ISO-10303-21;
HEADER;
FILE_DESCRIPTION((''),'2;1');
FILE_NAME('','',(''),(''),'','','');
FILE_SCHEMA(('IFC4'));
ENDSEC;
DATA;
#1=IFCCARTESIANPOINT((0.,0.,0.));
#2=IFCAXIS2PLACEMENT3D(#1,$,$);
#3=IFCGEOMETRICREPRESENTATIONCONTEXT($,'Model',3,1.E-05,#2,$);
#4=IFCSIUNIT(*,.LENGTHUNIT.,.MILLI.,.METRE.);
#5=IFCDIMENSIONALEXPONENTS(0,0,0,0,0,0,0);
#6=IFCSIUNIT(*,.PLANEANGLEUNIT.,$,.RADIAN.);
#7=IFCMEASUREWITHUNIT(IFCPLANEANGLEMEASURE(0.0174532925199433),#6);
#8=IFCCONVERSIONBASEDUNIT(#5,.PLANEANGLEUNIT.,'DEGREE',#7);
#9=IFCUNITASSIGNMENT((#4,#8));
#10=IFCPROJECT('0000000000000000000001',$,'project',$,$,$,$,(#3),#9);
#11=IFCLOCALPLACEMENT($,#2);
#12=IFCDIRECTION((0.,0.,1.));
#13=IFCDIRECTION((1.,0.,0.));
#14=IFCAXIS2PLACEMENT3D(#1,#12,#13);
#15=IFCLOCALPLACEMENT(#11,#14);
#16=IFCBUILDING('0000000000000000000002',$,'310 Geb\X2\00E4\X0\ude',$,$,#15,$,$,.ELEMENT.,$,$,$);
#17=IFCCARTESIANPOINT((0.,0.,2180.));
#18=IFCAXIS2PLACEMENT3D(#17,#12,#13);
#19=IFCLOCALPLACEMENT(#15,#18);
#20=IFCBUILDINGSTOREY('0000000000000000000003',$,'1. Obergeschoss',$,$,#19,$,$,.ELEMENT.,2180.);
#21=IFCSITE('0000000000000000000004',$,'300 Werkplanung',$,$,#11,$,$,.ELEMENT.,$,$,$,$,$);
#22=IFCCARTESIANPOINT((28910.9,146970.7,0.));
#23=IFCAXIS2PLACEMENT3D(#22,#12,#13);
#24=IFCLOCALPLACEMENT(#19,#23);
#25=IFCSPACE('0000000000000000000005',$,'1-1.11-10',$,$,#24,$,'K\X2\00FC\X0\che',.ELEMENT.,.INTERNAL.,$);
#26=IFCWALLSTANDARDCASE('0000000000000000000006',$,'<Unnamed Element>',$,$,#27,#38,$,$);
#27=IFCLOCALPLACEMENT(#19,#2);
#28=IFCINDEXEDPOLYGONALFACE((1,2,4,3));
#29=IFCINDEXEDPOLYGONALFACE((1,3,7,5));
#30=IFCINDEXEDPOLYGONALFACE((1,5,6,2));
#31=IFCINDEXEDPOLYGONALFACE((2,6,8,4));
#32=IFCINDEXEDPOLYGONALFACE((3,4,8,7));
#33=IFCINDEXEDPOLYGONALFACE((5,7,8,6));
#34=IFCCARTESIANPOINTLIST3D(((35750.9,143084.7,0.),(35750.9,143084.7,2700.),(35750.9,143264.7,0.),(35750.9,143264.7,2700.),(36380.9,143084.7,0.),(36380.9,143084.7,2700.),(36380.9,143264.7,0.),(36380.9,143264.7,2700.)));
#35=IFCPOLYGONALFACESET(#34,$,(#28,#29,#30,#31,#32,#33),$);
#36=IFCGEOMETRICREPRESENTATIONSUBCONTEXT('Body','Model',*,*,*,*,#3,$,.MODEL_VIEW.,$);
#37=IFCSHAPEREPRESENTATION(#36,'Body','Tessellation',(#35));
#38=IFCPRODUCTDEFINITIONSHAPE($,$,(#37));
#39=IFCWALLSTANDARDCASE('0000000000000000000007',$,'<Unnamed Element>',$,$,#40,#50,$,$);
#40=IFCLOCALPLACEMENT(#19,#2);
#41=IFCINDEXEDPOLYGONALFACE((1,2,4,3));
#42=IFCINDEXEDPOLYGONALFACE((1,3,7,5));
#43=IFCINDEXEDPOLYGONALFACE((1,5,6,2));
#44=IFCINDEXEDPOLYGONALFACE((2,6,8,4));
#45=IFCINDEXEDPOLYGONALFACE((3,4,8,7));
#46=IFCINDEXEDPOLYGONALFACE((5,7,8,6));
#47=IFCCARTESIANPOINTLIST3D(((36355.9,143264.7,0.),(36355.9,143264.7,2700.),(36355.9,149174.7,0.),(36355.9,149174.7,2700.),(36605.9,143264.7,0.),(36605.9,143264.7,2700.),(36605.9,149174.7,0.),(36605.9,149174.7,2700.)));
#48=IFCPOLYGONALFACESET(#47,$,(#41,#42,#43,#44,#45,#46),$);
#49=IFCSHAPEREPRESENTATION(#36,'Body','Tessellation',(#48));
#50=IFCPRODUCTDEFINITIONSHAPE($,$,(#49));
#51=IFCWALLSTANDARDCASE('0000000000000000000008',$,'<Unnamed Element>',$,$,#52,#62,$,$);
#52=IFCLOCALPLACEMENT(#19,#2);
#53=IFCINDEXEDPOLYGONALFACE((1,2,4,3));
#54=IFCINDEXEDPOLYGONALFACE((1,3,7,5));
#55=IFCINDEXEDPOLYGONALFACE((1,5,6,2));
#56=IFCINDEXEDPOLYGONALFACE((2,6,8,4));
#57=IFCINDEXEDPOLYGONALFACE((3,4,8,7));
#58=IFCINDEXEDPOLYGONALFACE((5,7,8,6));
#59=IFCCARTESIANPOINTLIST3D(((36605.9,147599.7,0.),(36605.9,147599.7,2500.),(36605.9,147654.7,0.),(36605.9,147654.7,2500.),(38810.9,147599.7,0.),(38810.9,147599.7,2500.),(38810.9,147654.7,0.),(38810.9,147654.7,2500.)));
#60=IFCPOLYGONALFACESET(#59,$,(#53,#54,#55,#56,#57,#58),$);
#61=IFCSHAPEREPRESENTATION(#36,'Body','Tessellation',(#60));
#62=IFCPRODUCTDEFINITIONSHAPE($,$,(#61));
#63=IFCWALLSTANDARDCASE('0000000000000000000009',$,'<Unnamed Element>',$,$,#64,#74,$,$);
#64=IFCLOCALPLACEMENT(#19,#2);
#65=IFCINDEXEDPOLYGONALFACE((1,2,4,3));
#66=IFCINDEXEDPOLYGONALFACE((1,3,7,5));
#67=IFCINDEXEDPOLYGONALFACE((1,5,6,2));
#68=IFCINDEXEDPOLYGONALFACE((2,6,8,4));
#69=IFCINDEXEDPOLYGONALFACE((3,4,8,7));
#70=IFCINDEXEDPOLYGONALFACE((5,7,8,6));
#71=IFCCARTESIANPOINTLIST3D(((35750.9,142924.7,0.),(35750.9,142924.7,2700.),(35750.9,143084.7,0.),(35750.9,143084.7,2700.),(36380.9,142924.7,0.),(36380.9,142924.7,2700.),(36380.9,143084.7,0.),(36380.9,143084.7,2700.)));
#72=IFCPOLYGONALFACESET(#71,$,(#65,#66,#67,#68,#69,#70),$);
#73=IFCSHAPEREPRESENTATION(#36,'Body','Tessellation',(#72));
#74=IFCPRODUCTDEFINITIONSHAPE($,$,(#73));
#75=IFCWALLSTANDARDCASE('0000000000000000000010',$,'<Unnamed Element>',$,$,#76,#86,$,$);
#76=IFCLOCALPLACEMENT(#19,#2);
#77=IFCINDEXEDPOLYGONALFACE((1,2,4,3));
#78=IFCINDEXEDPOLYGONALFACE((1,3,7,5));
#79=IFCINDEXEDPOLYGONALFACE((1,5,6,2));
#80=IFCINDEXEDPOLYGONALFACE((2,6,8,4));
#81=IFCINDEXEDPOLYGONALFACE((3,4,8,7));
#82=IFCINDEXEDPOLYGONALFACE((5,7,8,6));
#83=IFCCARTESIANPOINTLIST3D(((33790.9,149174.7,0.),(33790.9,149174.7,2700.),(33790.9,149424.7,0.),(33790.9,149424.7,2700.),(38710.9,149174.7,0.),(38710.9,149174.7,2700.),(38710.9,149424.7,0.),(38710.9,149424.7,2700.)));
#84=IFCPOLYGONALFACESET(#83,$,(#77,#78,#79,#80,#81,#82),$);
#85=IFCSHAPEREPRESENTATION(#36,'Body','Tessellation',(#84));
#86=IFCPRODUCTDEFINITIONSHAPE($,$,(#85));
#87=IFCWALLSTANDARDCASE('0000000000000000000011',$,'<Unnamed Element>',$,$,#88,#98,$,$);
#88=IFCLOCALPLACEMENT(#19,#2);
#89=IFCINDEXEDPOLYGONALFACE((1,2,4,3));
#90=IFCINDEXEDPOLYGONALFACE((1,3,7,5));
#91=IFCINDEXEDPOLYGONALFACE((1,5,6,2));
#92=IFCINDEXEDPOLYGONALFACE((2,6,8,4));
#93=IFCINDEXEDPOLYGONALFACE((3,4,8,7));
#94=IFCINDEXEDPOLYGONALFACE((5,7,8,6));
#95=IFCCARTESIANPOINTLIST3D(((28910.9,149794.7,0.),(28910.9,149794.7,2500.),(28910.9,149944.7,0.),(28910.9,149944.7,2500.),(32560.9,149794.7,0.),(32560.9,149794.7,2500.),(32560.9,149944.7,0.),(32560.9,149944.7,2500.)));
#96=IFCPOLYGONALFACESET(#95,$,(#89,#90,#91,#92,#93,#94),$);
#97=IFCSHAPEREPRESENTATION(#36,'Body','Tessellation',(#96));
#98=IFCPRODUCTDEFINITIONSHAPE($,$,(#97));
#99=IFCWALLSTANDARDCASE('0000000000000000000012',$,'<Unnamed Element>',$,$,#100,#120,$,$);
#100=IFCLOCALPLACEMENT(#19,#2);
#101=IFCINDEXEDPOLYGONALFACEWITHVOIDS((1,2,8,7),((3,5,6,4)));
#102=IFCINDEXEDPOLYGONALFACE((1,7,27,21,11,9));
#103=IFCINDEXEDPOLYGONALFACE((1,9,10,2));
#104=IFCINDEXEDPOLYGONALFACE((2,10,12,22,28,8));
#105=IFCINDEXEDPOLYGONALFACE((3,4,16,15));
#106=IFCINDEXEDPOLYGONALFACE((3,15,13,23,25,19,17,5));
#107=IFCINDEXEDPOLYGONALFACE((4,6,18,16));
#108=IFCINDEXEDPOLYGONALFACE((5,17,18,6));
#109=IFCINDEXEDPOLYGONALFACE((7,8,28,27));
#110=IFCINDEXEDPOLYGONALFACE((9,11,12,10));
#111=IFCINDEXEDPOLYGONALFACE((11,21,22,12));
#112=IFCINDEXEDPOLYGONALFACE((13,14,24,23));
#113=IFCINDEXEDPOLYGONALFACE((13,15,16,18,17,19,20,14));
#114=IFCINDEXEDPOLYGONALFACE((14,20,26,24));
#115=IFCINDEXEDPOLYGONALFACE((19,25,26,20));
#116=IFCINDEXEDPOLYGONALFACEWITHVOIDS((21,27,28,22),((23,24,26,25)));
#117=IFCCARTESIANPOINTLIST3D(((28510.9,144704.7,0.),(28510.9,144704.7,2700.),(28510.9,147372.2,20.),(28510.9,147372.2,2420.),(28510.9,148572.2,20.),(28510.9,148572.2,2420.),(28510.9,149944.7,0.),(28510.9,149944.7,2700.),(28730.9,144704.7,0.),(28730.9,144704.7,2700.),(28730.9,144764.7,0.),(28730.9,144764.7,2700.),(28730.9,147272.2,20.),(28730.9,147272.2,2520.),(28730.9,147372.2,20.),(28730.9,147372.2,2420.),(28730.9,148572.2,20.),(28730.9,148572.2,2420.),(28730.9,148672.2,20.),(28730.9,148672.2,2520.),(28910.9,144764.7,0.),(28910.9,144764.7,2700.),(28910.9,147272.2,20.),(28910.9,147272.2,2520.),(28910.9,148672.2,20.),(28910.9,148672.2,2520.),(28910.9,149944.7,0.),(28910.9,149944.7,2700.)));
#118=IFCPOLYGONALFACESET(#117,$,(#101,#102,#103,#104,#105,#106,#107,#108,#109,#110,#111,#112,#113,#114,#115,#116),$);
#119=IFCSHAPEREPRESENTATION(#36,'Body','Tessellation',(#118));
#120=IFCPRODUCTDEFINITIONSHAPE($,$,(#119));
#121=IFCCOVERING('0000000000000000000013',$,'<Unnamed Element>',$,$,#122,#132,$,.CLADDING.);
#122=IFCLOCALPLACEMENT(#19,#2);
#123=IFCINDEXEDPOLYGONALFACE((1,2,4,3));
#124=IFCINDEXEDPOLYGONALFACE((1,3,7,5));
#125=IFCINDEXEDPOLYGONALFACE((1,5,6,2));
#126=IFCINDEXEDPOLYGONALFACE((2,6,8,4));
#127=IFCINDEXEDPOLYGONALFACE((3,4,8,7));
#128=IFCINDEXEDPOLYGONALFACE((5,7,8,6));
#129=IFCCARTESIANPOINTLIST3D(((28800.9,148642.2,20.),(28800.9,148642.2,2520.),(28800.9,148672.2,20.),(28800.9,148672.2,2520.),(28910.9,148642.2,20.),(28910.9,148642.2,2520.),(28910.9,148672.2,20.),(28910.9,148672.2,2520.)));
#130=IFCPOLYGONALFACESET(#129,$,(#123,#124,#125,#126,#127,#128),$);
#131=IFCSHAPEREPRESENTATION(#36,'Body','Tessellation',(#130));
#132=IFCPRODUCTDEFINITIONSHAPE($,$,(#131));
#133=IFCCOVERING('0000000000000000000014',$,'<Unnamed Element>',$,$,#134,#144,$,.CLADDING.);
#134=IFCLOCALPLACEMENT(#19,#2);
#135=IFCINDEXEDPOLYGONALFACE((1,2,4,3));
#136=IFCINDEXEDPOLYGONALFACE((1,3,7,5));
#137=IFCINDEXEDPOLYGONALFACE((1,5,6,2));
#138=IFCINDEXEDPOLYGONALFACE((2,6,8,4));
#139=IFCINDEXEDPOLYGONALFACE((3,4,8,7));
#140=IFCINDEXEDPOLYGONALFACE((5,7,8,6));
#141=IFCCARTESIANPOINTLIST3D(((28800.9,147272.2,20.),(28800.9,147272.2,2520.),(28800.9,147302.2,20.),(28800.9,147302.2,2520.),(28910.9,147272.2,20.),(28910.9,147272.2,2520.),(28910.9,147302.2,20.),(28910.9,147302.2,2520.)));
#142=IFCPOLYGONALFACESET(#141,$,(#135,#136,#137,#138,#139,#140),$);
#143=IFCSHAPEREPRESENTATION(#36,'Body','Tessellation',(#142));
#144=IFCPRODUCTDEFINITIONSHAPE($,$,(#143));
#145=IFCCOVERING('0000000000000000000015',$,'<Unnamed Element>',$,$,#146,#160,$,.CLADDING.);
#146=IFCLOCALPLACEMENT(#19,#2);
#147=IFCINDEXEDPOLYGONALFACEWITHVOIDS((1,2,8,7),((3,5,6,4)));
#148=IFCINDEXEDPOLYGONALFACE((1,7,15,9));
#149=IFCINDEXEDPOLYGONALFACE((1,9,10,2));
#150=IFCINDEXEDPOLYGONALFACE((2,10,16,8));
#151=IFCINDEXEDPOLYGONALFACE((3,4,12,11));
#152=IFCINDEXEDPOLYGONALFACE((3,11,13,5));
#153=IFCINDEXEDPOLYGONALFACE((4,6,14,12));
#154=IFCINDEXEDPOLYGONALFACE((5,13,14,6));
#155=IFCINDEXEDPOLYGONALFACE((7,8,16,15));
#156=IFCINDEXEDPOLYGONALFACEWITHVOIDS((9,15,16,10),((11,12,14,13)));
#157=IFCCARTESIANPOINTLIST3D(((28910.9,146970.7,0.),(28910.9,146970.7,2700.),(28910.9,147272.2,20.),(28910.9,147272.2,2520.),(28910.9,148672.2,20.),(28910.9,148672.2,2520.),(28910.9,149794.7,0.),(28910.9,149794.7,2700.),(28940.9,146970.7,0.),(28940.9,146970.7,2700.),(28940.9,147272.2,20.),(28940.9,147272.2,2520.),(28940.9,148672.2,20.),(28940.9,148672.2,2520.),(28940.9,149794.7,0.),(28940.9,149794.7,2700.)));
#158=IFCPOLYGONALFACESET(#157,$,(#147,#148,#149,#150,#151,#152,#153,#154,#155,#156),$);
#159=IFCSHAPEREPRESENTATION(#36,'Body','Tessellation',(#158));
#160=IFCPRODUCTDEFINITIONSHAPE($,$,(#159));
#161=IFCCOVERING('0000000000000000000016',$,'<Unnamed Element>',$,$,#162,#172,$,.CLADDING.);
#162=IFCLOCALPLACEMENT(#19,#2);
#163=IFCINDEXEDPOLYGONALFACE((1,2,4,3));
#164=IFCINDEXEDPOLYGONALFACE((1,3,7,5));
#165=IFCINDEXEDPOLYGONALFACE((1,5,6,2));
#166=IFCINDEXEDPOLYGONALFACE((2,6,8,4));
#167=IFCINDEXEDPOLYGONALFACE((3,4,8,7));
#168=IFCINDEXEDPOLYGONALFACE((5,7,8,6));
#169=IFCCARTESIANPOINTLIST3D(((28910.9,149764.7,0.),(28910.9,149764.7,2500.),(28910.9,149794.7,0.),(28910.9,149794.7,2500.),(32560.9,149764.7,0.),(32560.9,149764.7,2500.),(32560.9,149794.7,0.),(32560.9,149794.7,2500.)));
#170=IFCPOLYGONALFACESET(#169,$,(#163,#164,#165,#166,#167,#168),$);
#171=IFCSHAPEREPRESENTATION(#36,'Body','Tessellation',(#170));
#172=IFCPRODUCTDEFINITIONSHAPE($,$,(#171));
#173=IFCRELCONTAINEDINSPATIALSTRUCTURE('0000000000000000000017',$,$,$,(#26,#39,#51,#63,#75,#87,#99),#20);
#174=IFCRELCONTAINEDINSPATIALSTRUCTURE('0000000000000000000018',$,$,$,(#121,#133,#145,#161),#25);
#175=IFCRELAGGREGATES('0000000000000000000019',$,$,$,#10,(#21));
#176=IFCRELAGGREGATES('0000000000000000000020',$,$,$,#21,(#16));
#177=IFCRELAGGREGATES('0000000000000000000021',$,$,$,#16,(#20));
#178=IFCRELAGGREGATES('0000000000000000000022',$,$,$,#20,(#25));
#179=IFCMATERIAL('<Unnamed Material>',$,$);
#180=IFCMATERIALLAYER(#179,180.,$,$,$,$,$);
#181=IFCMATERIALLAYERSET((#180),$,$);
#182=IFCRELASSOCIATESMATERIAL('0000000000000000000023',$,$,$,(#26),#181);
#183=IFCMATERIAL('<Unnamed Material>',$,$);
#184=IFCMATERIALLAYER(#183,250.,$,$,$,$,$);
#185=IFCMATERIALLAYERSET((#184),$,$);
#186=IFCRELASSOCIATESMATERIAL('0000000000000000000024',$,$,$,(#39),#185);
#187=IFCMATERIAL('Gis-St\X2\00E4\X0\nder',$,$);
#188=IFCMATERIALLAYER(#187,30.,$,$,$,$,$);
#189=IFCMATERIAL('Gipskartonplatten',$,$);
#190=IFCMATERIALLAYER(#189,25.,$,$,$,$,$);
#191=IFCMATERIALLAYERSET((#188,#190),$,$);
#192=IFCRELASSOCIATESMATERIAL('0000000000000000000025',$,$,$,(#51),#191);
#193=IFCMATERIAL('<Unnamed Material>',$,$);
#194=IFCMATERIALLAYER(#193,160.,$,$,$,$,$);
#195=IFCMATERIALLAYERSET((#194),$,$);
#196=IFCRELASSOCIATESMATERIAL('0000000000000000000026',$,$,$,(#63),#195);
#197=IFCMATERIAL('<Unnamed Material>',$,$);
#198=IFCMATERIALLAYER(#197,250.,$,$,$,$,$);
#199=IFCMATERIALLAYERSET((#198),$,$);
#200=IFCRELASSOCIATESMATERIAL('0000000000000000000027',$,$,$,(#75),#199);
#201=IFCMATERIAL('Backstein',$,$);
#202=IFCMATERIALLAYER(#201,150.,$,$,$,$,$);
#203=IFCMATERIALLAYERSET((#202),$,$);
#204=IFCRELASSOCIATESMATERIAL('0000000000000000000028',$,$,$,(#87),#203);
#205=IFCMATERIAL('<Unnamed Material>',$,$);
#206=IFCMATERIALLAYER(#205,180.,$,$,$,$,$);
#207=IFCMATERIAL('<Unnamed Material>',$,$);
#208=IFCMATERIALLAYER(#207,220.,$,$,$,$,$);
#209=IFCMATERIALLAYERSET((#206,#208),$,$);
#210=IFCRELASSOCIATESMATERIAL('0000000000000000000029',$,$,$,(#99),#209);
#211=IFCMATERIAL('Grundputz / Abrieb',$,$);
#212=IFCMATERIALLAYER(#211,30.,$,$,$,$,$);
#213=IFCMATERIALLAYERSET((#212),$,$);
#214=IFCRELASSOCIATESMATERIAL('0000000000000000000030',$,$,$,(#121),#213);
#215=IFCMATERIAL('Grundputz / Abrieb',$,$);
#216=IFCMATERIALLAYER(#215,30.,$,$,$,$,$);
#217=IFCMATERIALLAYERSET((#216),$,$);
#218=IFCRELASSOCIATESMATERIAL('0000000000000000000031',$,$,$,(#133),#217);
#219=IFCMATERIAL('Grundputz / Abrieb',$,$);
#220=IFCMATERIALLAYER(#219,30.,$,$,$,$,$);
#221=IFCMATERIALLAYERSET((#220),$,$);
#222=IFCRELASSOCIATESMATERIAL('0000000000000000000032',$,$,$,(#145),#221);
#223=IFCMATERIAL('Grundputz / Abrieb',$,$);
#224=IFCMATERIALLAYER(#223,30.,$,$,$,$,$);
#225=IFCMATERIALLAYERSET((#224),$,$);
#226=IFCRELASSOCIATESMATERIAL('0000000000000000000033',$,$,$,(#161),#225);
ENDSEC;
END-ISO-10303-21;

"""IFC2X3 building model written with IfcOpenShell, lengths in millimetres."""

from ifc_helpers import new_model, entity, si_unit, converted_unit, frame, frame_2d, origin, origin_with_axes, place, context, subcontext, project, spatial, polyline, rectangle, outline, extrude, material, layer, layer_set, layer_usage, element, save


model = new_model("IFC2X3")

# Units and contexts
model_context = context("Model", 3, precision=1e-05, world=origin())
body_context = subcontext(model_context, "Body", "Model", "MODEL_VIEW")
ifc_project = project(units=[si_unit("LENGTHUNIT", "METRE", prefix="MILLI"), converted_unit("PLANEANGLEUNIT", "DEGREE", entity("IfcPlaneAngleMeasure", 0.0174532925199433), si_unit("PLANEANGLEUNIT", "RADIAN"), dimensions=[0, 0, 0, 0, 0, 0, 0])], contexts=[model_context])

# Site, building, storey
site_placement = place(None, origin())
site = spatial("IfcSite", under=ifc_project, at=site_placement, Name="300 Werkplanung", CompositionType="ELEMENT")
building_placement = place(site_placement, origin_with_axes())
building = spatial("IfcBuilding", under=site, at=building_placement, Name="310 Gebäude", CompositionType="ELEMENT")
storey_placement = place(building_placement, frame((0.0, 0.0, 2180.0), z_axis=(0.0, 0.0, 1.0), x_axis=(1.0, 0.0, 0.0)))
storey = spatial("IfcBuildingStorey", under=building, at=storey_placement, Name="1. Obergeschoss", CompositionType="ELEMENT", Elevation=2180.0)

# Walls
ifc_material_1 = material(Name="<Unnamed Material>")
ifc_layer_1 = layer(ifc_material_1, 180.0)
ifc_layer_set_1 = layer_set([ifc_layer_1])
ifc_layer_usage_1 = layer_usage(ifc_layer_set_1, "AXIS2", "POSITIVE", 0.0)
wall_1_placement = place(storey_placement, frame((35750.9, 143084.7, 0.0), z_axis=(0.0, 0.0, 1.0), x_axis=(1.0, 0.0, 0.0)))
element("IfcWallStandardCase", 1, at=wall_1_placement, inside=storey, material=ifc_layer_usage_1, Name="<Unnamed Element>", context=body_context, shape_type="SweptSolid", body=[
    extrude(rectangle(XDim=630.0, YDim=180.0, at=frame_2d((315.0, 90.0), x_axis=(1.0, 0.0))), origin_with_axes(), (0.0, 0.0, 1.0), 2700.0),
])
ifc_material_2 = material(Name="<Unnamed Material>")
ifc_layer_2 = layer(ifc_material_2, 250.0)
ifc_layer_set_2 = layer_set([ifc_layer_2])
ifc_layer_usage_2 = layer_usage(ifc_layer_set_2, "AXIS2", "POSITIVE", -125.0)
wall_2_placement = place(storey_placement, frame((36605.9, 143264.7, 0.0), z_axis=(0.0, 0.0, 1.0), x_axis=(0.0, 1.0, 0.0)))
element("IfcWallStandardCase", 2, at=wall_2_placement, inside=storey, material=ifc_layer_usage_2, Name="<Unnamed Element>", context=body_context, shape_type="SweptSolid", body=[
    extrude(rectangle(XDim=5910.0, YDim=250.0, at=frame_2d((2955.0, 125.0), x_axis=(1.0, 0.0))), origin_with_axes(), (0.0, 0.0, 1.0), 2700.0),
])
ifc_material_3 = material(Name="Gis-Ständer")
ifc_layer_3 = layer(ifc_material_3, 30.0)
ifc_material_4 = material(Name="Gipskartonplatten")
ifc_layer_4 = layer(ifc_material_4, 25.0)
ifc_layer_set_3 = layer_set([ifc_layer_3, ifc_layer_4])
ifc_layer_usage_3 = layer_usage(ifc_layer_set_3, "AXIS2", "POSITIVE", -55.0)
wall_3_placement = place(storey_placement, frame((36605.9, 147599.7, 0.0), z_axis=(0.0, 0.0, 1.0), x_axis=(1.0, 0.0, 0.0)))
element("IfcWallStandardCase", 3, at=wall_3_placement, inside=storey, material=ifc_layer_usage_3, Name="<Unnamed Element>", context=body_context, shape_type="SweptSolid", body=[
    extrude(rectangle(XDim=2205.0, YDim=55.0, at=frame_2d((1102.5, 27.5), x_axis=(1.0, 0.0))), origin_with_axes(), (0.0, 0.0, 1.0), 2500.0),
])
ifc_material_5 = material(Name="<Unnamed Material>")
ifc_layer_5 = layer(ifc_material_5, 160.0)
ifc_layer_set_4 = layer_set([ifc_layer_5])
ifc_layer_usage_4 = layer_usage(ifc_layer_set_4, "AXIS2", "POSITIVE", 0.0)
wall_4_placement = place(storey_placement, frame((36380.9, 143084.7, 0.0), z_axis=(0.0, 0.0, 1.0), x_axis=(-1.0, 0.0, 0.0)))
element("IfcWallStandardCase", 4, at=wall_4_placement, inside=storey, material=ifc_layer_usage_4, Name="<Unnamed Element>", context=body_context, shape_type="SweptSolid", body=[
    extrude(rectangle(XDim=630.0, YDim=160.0, at=frame_2d((315.0, 80.0), x_axis=(1.0, 0.0))), origin_with_axes(), (0.0, 0.0, 1.0), 2700.0),
])
ifc_material_6 = material(Name="<Unnamed Material>")
ifc_layer_6 = layer(ifc_material_6, 250.0)
ifc_layer_set_5 = layer_set([ifc_layer_6])
ifc_layer_usage_5 = layer_usage(ifc_layer_set_5, "AXIS2", "POSITIVE", -250.0)
wall_5_placement = place(storey_placement, frame((33790.9, 149174.7, 0.0), z_axis=(0.0, 0.0, 1.0), x_axis=(1.0, 0.0, 0.0)))
element("IfcWallStandardCase", 5, at=wall_5_placement, inside=storey, material=ifc_layer_usage_5, Name="<Unnamed Element>", context=body_context, shape_type="SweptSolid", body=[
    extrude(rectangle(XDim=4920.0, YDim=250.0, at=frame_2d((2460.0, 125.0), x_axis=(1.0, 0.0))), origin_with_axes(), (0.0, 0.0, 1.0), 2700.0),
])
ifc_material_7 = material(Name="Backstein")
ifc_layer_7 = layer(ifc_material_7, 150.0)
ifc_layer_set_6 = layer_set([ifc_layer_7])
ifc_layer_usage_6 = layer_usage(ifc_layer_set_6, "AXIS2", "POSITIVE", 0.0)
wall_6_placement = place(storey_placement, frame((28910.9, 149794.7, 0.0), z_axis=(0.0, 0.0, 1.0), x_axis=(1.0, 0.0, 0.0)))
element("IfcWallStandardCase", 6, at=wall_6_placement, inside=storey, material=ifc_layer_usage_6, Name="<Unnamed Element>", context=body_context, shape_type="SweptSolid", body=[
    extrude(rectangle(XDim=3650.0, YDim=150.0, at=frame_2d((1825.0, 75.0), x_axis=(1.0, 0.0))), origin_with_axes(), (0.0, 0.0, 1.0), 2500.0),
])

# Wall, opening
ifc_material_8 = material(Name="<Unnamed Material>")
ifc_layer_8 = layer(ifc_material_8, 180.0)
ifc_material_9 = material(Name="<Unnamed Material>")
ifc_layer_9 = layer(ifc_material_9, 220.0)
ifc_layer_set_7 = layer_set([ifc_layer_8, ifc_layer_9])
ifc_layer_usage_7 = layer_usage(ifc_layer_set_7, "AXIS2", "POSITIVE", -175.0)
wall_7_placement = place(storey_placement, frame((28910.9, 144764.7, 0.0), z_axis=(0.0, 0.0, 1.0), x_axis=(0.0, 1.0, 0.0)))
wall_7 = element("IfcWallStandardCase", 7, at=wall_7_placement, inside=storey, material=ifc_layer_usage_7, Name="<Unnamed Element>", context=body_context, shape_type="SweptSolid", body=[
    extrude(outline(polyline([(-60.0, 400.0), (-60.0, 180.0), (0.0, 180.0), (0.0, 0.0), (5180.0, 0.0), (5180.0, 400.0), (-60.0, 400.0)])), origin_with_axes(), (0.0, 0.0, 1.0), 2700.0),
])
opening_placement = place(wall_7_placement, frame((2507.5, 0.0, 20.0), z_axis=(0.0, 1.0, 0.0), x_axis=(0.0, 0.0, 1.0)))
element("IfcOpeningElement", 8, at=opening_placement, cuts=wall_7, ObjectType="Opening", context=body_context, shape_type="SweptSolid", body=[
    extrude(rectangle(XDim=2500.0, YDim=1400.0, at=frame_2d((1250.0, 700.0), x_axis=(1.0, 0.0))), origin_with_axes(), (0.0, 0.0, 1.0), 180.0),
    extrude(rectangle(XDim=2400.0, YDim=1200.0, at=frame_2d((1200.0, 600.0), x_axis=(1.0, 0.0))), frame((0.0, 100.0, 180.0), z_axis=(0.0, 0.0, 1.0), x_axis=(1.0, 0.0, 0.0)), (0.0, 0.0, 1.0), 220.0),
])

# Shared definitions
space_1_placement = place(storey_placement, frame((28910.9, 146970.7, 0.0), z_axis=(0.0, 0.0, 1.0), x_axis=(1.0, 0.0, 0.0)))
space_1 = spatial("IfcSpace", under=storey, at=space_1_placement, Name="1-1.11-10", LongName="Küche", CompositionType="ELEMENT", InteriorOrExteriorSpace="INTERNAL")

# Coverings
ifc_material_10 = material(Name="Grundputz / Abrieb")
ifc_layer_10 = layer(ifc_material_10, 30.0)
ifc_layer_set_8 = layer_set([ifc_layer_10])
ifc_layer_usage_8 = layer_usage(ifc_layer_set_8, "AXIS3", "POSITIVE", 0.0)
covering_1_placement = place(space_1_placement, frame((0.0, 1701.5, 20.0), z_axis=(0.0, 0.0, 1.0), x_axis=(-1.0, 0.0, 0.0)))
element("IfcCovering", 9, at=covering_1_placement, inside=space_1, material=ifc_layer_usage_8, Name="<Unnamed Element>", PredefinedType="CLADDING", context=body_context, shape_type="SweptSolid", body=[
    extrude(rectangle(XDim=2500.0, YDim=110.0, at=frame_2d((-55.0, 1250.0), x_axis=(0.0, 1.0))), frame((110.0, 0.0, 2500.0), z_axis=(0.0, 1.0, 0.0), x_axis=(1.0, 0.0, 0.0)), (0.0, 0.0, 1.0), 30.0),
])
ifc_material_11 = material(Name="Grundputz / Abrieb")
ifc_layer_11 = layer(ifc_material_11, 30.0)
ifc_layer_set_9 = layer_set([ifc_layer_11])
ifc_layer_usage_9 = layer_usage(ifc_layer_set_9, "AXIS3", "POSITIVE", 0.0)
covering_2_placement = place(space_1_placement, frame((-110.0, 301.5, 20.0), z_axis=(0.0, 0.0, 1.0), x_axis=(1.0, 0.0, 0.0)))
element("IfcCovering", 10, at=covering_2_placement, inside=space_1, material=ifc_layer_usage_9, Name="<Unnamed Element>", PredefinedType="CLADDING", context=body_context, shape_type="SweptSolid", body=[
    extrude(rectangle(XDim=2500.0, YDim=110.0, at=frame_2d((-55.0, 1250.0), x_axis=(0.0, 1.0))), frame((110.0, 0.0, 2500.0), z_axis=(0.0, 1.0, 0.0), x_axis=(1.0, 0.0, 0.0)), (0.0, 0.0, 1.0), 30.0),
])
ifc_material_12 = material(Name="Grundputz / Abrieb")
ifc_layer_12 = layer(ifc_material_12, 30.0)
ifc_layer_set_10 = layer_set([ifc_layer_12])
ifc_layer_usage_10 = layer_usage(ifc_layer_set_10, "AXIS3", "POSITIVE", 0.0)
covering_3_placement = place(space_1_placement, frame((0.0, 2824.0, 0.0), z_axis=(0.0, 0.0, 1.0), x_axis=(0.0, -1.0, 0.0)))
element("IfcCovering", 11, at=covering_3_placement, inside=space_1, material=ifc_layer_usage_10, Name="<Unnamed Element>", PredefinedType="CLADDING", context=body_context, shape_type="SweptSolid", body=[
    extrude(outline(polyline([(2824.0, 0.0), (2824.0, -2700.0), (0.0, -2700.0), (0.0, 0.0), (2824.0, 0.0)]), holes=[polyline([(2522.5, -20.0), (1122.5, -20.0), (1122.5, -2520.0), (2522.5, -2520.0), (2522.5, -20.0)])]), frame((0.0, 0.0, 0.0), z_axis=(0.0, 1.0, 0.0), x_axis=(1.0, 0.0, 0.0)), (0.0, 0.0, 1.0), 30.0),
])
ifc_material_13 = material(Name="Grundputz / Abrieb")
ifc_layer_13 = layer(ifc_material_13, 30.0)
ifc_layer_set_11 = layer_set([ifc_layer_13])
ifc_layer_usage_11 = layer_usage(ifc_layer_set_11, "AXIS3", "POSITIVE", 0.0)
covering_4_placement = place(space_1_placement, frame((3650.0, 2824.0, 0.0), z_axis=(0.0, 0.0, 1.0), x_axis=(-1.0, 0.0, 0.0)))
element("IfcCovering", 12, at=covering_4_placement, inside=space_1, material=ifc_layer_usage_11, Name="<Unnamed Element>", PredefinedType="CLADDING", context=body_context, shape_type="SweptSolid", body=[
    extrude(rectangle(XDim=2500.0, YDim=3650.0, at=frame_2d((-1825.0, 1250.0), x_axis=(0.0, 1.0))), frame((3650.0, 0.0, 2500.0), z_axis=(0.0, 1.0, 0.0), x_axis=(1.0, 0.0, 0.0)), (0.0, 0.0, 1.0), 30.0),
])

save(model, "model.ifc")
